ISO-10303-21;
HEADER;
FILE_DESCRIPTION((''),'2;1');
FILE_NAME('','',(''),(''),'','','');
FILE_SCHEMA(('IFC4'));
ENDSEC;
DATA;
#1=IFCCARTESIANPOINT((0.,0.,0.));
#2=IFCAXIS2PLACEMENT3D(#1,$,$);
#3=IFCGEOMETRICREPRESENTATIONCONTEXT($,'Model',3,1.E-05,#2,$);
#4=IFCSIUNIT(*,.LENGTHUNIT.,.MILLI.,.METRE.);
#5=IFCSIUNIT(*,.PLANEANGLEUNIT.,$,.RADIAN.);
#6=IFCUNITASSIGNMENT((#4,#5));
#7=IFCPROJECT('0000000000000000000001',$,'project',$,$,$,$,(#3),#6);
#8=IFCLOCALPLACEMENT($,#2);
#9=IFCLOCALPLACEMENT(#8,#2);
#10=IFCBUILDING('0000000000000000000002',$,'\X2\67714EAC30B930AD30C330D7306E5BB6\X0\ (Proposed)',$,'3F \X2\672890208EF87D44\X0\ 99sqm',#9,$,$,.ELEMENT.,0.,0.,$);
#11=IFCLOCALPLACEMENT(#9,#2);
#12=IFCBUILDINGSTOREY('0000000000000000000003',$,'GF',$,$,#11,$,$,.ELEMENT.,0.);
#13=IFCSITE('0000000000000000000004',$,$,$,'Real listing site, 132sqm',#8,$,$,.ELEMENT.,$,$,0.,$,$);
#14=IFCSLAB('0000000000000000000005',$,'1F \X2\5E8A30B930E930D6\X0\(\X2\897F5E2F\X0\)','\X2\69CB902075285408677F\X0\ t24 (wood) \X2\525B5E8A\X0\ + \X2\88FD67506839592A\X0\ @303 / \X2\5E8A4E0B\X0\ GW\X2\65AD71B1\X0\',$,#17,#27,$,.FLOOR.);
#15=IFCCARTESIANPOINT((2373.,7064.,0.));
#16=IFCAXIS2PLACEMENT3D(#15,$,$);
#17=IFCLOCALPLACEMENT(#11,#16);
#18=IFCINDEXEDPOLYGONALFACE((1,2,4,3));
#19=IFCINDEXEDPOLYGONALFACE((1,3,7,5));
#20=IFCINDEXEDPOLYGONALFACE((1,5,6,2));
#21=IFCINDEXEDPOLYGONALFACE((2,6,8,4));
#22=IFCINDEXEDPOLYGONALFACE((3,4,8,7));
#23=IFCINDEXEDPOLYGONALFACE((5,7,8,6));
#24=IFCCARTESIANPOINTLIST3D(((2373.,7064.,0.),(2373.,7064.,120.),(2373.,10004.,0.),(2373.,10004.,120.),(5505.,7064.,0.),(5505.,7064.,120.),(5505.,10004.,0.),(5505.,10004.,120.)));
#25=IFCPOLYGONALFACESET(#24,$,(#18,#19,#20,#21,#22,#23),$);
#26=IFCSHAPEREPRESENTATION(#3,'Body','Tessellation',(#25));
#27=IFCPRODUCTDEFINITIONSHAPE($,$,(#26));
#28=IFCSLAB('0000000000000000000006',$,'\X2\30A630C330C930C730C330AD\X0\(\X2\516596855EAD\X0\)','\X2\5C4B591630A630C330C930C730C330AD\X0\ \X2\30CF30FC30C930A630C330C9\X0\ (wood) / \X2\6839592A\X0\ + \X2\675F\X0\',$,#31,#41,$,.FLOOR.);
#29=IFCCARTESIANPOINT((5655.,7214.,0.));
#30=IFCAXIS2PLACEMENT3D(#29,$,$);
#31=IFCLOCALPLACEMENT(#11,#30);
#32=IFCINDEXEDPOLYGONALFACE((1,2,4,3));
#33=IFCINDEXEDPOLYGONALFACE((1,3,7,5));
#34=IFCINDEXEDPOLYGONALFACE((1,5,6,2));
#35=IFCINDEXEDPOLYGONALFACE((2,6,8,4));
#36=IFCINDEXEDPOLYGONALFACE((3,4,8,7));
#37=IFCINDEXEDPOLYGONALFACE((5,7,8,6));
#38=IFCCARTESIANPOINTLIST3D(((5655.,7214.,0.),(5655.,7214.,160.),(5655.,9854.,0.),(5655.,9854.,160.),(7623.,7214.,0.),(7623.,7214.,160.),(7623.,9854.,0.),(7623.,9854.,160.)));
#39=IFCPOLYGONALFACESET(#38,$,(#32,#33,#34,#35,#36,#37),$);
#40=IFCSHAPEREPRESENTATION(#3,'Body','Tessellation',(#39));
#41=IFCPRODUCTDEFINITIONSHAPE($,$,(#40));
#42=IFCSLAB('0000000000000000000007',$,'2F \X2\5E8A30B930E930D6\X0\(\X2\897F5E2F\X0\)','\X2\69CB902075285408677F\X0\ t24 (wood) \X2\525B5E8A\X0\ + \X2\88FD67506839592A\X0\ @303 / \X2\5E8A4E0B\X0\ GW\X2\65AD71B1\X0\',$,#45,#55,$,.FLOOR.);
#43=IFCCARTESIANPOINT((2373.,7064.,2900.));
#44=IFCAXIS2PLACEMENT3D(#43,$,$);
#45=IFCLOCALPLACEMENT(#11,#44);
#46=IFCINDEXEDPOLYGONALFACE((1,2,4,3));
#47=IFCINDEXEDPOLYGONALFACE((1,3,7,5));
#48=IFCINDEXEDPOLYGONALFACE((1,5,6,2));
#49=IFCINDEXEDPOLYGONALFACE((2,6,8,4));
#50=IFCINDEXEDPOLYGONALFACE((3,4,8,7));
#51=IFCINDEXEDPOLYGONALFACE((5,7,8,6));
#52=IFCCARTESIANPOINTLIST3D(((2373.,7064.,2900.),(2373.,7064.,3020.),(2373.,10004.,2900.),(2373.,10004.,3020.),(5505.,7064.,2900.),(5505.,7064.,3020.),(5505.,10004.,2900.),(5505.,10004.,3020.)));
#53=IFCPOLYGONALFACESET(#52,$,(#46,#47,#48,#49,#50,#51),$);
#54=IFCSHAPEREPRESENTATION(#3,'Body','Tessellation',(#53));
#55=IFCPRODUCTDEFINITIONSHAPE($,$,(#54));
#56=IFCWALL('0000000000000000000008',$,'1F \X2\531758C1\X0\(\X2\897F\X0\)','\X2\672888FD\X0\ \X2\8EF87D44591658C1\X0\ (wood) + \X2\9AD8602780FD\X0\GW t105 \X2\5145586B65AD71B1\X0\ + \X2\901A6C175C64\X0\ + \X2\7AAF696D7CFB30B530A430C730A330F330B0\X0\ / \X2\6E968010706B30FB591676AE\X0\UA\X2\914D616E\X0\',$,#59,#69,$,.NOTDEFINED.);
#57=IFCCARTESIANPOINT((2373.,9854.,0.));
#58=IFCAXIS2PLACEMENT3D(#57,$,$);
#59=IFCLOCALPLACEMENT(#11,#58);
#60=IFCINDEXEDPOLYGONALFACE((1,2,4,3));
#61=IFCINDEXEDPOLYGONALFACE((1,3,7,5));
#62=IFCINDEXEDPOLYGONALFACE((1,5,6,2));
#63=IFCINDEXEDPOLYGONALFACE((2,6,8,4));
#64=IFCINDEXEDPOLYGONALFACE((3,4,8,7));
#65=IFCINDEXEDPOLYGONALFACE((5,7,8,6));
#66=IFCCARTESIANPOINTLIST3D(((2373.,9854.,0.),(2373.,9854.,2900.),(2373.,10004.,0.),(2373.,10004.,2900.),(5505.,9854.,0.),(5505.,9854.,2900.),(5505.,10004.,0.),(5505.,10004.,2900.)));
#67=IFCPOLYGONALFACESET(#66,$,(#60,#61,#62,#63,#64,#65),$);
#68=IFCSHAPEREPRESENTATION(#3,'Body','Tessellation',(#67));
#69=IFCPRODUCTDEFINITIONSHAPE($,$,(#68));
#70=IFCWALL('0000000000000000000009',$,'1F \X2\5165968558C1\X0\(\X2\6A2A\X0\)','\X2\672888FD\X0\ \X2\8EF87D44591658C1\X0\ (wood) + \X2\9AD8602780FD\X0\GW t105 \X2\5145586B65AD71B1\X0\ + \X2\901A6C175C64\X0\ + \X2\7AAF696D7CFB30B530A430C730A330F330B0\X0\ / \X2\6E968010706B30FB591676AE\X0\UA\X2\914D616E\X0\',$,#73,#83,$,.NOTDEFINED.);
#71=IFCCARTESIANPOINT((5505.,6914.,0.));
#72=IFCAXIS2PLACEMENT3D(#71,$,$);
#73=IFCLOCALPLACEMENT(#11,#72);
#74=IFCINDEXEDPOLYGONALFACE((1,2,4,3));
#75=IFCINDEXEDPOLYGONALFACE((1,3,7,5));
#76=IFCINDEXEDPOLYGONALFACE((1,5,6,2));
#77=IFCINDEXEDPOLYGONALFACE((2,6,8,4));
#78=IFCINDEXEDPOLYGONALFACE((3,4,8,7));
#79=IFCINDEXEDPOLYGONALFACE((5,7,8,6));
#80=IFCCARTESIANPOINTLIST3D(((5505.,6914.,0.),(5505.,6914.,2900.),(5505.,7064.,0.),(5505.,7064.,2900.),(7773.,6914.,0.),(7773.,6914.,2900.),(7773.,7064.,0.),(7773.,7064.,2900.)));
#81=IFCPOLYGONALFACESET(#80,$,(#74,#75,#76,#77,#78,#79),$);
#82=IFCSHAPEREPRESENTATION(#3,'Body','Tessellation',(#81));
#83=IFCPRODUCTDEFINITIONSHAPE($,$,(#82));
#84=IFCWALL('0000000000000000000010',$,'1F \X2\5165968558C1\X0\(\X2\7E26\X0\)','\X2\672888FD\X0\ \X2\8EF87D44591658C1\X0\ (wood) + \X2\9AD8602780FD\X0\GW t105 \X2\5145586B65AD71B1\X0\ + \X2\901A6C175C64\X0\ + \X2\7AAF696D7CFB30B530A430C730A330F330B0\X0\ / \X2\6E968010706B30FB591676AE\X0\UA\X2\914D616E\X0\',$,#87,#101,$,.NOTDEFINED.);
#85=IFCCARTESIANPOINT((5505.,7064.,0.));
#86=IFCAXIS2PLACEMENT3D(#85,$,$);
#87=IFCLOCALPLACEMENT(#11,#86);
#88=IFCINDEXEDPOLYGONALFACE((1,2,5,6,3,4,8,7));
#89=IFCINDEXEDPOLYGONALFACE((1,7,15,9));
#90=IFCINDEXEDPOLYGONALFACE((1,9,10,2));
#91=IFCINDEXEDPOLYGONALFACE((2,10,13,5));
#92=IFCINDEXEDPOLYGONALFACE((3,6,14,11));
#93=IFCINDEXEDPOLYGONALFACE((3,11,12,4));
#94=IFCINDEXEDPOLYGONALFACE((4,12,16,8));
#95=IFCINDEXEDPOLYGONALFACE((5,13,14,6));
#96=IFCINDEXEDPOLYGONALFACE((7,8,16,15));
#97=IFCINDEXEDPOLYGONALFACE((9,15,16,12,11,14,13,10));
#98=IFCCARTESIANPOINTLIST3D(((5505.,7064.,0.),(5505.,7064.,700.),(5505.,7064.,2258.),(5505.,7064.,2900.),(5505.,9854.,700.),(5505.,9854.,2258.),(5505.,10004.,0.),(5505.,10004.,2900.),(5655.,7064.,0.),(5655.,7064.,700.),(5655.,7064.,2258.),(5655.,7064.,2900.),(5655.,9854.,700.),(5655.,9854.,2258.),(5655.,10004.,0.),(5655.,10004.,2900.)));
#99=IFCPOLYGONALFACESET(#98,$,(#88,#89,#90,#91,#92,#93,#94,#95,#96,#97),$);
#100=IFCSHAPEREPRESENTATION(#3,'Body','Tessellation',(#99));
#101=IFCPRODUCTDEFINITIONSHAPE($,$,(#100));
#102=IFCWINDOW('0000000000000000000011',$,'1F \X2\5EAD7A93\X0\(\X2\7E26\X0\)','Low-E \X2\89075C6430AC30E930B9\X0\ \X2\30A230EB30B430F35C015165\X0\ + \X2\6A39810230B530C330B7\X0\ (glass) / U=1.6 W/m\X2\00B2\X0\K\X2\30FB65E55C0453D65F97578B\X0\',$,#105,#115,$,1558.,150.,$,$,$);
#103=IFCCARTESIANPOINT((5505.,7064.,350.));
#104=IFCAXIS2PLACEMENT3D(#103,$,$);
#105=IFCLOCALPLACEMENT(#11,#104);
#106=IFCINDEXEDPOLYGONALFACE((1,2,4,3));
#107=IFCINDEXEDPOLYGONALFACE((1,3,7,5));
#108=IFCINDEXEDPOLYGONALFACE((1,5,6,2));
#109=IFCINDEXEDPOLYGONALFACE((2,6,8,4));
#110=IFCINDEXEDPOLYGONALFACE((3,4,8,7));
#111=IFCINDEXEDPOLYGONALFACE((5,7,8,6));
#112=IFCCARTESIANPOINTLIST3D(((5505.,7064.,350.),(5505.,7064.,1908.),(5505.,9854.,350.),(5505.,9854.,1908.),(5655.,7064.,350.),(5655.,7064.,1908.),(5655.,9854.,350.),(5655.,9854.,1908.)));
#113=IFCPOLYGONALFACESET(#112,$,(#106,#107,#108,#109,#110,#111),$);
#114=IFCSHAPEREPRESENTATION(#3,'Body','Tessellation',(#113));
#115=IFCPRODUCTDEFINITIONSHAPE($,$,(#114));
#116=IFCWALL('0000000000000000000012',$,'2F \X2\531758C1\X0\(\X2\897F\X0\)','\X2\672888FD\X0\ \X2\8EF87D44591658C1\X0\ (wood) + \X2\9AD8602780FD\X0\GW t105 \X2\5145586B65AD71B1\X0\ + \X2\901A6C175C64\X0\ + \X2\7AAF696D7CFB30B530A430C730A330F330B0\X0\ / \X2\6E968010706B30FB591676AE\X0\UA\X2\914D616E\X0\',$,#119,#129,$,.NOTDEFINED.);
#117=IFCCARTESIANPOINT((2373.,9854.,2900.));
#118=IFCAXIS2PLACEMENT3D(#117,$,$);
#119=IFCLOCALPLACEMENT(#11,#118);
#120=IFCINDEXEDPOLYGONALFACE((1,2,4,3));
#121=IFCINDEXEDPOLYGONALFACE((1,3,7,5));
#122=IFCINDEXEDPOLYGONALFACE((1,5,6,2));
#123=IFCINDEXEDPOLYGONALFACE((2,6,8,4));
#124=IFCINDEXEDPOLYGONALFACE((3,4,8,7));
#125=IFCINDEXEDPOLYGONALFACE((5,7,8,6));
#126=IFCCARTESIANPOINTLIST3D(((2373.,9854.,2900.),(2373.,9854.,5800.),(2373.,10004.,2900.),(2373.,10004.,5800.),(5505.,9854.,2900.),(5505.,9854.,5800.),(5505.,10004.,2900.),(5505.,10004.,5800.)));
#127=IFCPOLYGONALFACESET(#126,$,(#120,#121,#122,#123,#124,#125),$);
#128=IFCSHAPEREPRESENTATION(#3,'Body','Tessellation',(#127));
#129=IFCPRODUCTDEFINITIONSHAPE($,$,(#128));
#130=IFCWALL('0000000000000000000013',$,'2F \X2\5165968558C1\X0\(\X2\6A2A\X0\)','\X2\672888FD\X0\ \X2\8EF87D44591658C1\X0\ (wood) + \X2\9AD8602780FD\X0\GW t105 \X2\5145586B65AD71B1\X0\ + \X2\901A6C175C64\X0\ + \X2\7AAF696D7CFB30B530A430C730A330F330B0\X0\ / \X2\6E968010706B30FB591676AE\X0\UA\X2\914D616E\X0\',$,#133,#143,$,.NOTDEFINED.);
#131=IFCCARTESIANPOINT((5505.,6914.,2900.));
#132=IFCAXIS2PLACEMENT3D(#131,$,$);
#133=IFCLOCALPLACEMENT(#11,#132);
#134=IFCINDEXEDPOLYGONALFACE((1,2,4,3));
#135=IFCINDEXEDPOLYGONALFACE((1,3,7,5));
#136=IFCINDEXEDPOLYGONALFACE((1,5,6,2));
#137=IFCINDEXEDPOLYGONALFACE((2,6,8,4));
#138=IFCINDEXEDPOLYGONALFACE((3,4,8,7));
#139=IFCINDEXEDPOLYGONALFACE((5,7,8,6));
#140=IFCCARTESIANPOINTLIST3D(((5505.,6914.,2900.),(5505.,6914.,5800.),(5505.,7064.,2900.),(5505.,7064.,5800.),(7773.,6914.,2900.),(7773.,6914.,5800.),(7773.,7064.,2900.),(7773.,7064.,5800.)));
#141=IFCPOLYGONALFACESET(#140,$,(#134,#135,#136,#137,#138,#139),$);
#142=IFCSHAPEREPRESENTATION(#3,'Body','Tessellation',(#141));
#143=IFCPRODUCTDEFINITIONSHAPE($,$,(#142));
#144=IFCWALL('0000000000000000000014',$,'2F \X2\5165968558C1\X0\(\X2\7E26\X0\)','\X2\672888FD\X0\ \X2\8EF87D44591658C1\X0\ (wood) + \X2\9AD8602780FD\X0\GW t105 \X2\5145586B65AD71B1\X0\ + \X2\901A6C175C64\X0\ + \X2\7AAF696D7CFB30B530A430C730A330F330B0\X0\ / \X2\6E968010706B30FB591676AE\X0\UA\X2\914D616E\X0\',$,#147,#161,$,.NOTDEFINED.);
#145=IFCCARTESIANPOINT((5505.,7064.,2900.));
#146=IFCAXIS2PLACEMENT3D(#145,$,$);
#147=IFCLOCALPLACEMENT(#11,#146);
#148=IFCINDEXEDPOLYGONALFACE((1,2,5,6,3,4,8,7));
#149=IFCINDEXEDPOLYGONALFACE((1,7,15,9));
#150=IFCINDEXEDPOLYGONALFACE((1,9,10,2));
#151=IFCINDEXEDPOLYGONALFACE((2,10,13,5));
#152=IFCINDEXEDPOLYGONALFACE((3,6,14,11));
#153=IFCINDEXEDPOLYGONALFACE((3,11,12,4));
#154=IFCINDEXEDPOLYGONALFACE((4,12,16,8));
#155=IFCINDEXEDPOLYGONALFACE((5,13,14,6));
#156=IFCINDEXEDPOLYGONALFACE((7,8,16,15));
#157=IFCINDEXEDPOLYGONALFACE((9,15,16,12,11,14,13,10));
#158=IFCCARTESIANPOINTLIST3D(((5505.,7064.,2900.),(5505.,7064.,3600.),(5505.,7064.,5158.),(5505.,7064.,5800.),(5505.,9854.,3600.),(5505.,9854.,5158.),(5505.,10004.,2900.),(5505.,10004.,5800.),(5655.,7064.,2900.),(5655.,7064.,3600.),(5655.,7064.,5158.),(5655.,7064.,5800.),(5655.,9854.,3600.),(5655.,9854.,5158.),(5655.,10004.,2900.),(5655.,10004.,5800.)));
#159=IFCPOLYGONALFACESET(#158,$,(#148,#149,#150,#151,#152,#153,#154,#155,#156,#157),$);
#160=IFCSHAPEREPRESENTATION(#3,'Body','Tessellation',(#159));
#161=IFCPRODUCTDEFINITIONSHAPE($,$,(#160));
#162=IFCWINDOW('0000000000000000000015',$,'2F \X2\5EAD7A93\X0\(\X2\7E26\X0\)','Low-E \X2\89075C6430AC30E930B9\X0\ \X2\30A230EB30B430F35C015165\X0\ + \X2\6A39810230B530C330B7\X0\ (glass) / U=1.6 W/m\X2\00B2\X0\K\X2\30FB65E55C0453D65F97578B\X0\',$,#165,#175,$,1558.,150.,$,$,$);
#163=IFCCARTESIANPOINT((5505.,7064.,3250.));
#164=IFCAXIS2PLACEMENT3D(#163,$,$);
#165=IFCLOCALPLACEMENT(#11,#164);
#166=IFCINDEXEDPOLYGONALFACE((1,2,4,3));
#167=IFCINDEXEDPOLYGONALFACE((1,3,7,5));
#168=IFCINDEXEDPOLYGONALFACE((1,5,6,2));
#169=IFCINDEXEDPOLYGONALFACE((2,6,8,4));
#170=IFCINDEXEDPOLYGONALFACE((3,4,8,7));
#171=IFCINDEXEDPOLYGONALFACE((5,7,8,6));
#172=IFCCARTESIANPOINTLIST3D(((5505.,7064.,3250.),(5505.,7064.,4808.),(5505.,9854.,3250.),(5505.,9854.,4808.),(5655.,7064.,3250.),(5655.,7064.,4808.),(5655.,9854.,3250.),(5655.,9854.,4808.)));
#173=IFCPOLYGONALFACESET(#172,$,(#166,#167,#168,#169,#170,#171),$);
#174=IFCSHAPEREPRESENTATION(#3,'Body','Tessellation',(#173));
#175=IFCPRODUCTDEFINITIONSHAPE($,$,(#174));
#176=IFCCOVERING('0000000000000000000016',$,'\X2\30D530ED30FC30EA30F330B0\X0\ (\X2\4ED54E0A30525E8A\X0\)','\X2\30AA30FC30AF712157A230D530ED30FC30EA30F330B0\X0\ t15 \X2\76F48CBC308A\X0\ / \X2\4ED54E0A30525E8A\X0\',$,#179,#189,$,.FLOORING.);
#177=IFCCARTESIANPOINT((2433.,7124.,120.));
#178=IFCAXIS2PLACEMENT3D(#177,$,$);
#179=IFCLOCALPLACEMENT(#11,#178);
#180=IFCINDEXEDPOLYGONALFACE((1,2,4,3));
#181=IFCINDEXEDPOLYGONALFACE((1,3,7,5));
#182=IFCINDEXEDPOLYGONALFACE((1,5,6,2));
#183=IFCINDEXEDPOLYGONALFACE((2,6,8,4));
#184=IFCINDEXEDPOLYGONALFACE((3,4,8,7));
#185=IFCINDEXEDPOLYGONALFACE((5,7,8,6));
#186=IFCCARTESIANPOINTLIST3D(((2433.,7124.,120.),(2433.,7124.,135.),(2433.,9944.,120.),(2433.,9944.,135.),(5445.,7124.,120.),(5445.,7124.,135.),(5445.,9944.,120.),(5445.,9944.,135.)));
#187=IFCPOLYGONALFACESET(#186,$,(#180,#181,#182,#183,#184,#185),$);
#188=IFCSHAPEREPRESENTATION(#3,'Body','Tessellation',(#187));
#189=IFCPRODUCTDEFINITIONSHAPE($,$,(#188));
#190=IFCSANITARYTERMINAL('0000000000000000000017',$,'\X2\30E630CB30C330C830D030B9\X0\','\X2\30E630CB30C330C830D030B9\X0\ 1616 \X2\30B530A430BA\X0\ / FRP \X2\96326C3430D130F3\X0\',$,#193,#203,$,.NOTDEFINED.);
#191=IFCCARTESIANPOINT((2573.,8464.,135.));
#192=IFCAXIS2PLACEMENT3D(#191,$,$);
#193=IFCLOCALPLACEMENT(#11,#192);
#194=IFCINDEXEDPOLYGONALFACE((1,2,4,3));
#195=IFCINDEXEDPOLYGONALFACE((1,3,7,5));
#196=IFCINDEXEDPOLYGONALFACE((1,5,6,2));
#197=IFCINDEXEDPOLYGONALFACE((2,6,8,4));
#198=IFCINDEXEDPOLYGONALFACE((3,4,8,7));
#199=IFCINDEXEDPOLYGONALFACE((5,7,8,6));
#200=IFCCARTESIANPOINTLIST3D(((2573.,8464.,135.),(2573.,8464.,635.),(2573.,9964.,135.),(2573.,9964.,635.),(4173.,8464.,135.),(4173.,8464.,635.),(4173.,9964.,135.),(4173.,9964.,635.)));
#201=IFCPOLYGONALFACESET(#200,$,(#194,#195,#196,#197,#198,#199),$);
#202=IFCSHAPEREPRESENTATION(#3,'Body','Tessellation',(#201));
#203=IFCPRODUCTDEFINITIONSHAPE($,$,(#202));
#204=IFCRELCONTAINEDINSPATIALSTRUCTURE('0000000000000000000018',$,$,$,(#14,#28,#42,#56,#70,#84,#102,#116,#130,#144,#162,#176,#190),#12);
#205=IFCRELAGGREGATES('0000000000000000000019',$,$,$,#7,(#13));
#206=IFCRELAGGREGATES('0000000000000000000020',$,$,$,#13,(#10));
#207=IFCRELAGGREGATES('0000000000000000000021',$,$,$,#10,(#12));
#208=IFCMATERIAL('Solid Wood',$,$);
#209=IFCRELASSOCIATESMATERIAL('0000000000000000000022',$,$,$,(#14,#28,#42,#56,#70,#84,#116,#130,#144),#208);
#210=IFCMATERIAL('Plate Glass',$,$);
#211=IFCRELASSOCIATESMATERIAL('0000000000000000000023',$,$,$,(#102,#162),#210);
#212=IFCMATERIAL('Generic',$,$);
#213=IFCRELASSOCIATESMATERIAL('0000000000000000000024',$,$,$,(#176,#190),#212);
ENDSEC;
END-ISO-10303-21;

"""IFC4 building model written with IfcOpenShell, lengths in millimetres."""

from ifc_helpers import new_model, si_unit, frame, frame_2d, origin, place, context, project, spatial, rectangle, extrude, material, element, fill, save


model = new_model("IFC4")

# Units and contexts
model_context = context("Model", 3, precision=1e-05, world=origin())
ifc_project = project(units=[si_unit("LENGTHUNIT", "METRE", prefix="MILLI"), si_unit("PLANEANGLEUNIT", "RADIAN")], contexts=[model_context])

# Site, building, storey
site_placement = place(None, origin())
site = spatial("IfcSite", under=ifc_project, at=site_placement, ObjectType="Real listing site, 132sqm", CompositionType="ELEMENT", RefElevation=0.0)
building_placement = place(site_placement, origin())
building = spatial("IfcBuilding", under=site, at=building_placement, Name="東京スキップの家 (Proposed)", ObjectType="3F 木造軸組 99sqm", CompositionType="ELEMENT", ElevationOfRefHeight=0.0, ElevationOfTerrain=0.0)
storey_placement = place(building_placement, origin())
storey = spatial("IfcBuildingStorey", under=building, at=storey_placement, Name="GF", CompositionType="ELEMENT", Elevation=0.0)

# Slabs
ifc_material_1 = material(Name="Solid Wood")
slab_1_placement = place(storey_placement, frame((2373.0, 7064.0, 0.0)))
element("IfcSlab", 1, at=slab_1_placement, inside=storey, material=ifc_material_1, Name="1F 床スラブ(西帯)", Description="構造用合板 t24 (wood) 剛床 + 製材根太 @303 / 床下 GW断熱", PredefinedType="FLOOR", context=model_context, shape_type="SweptSolid", body=[
    extrude(rectangle(XDim=3132.0, YDim=2940.0, at=frame_2d((1566.0, 1470.0))), frame((2373.0, 7064.0, 0.0)), (0.0, 0.0, 1.0), 120.0),
])
slab_2_placement = place(storey_placement, frame((5655.0, 7214.0, 0.0)))
element("IfcSlab", 2, at=slab_2_placement, inside=storey, material=ifc_material_1, Name="ウッドデッキ(入隅庭)", Description="屋外ウッドデッキ ハードウッド (wood) / 根太 + 束", PredefinedType="FLOOR", context=model_context, shape_type="SweptSolid", body=[
    extrude(rectangle(XDim=1968.0, YDim=2640.0, at=frame_2d((984.0, 1320.0))), frame((5655.0, 7214.0, 0.0)), (0.0, 0.0, 1.0), 160.0),
])
slab_3_placement = place(storey_placement, frame((2373.0, 7064.0, 2900.0)))
element("IfcSlab", 3, at=slab_3_placement, inside=storey, material=ifc_material_1, Name="2F 床スラブ(西帯)", Description="構造用合板 t24 (wood) 剛床 + 製材根太 @303 / 床下 GW断熱", PredefinedType="FLOOR", context=model_context, shape_type="SweptSolid", body=[
    extrude(rectangle(XDim=3132.0, YDim=2940.0, at=frame_2d((1566.0, 1470.0))), frame((2373.0, 7064.0, 2900.0)), (0.0, 0.0, 1.0), 120.0),
])

# Walls
wall_1_placement = place(storey_placement, frame((2373.0, 9854.0, 0.0)))
element("IfcWall", 4, at=wall_1_placement, inside=storey, material=ifc_material_1, Name="1F 北壁(西)", Description="木製 軸組外壁 (wood) + 高性能GW t105 充填断熱 + 通気層 + 窯業系サイディング / 準耐火・外皮UA配慮", PredefinedType="NOTDEFINED", context=model_context, shape_type="SweptSolid", body=[
    extrude(rectangle(XDim=3132.0, YDim=150.0, at=frame_2d((1566.0, 75.0))), frame((2373.0, 9854.0, 0.0)), (0.0, 0.0, 1.0), 2900.0),
])
wall_2_placement = place(storey_placement, frame((5505.0, 6914.0, 0.0)))
element("IfcWall", 5, at=wall_2_placement, inside=storey, material=ifc_material_1, Name="1F 入隅壁(横)", Description="木製 軸組外壁 (wood) + 高性能GW t105 充填断熱 + 通気層 + 窯業系サイディング / 準耐火・外皮UA配慮", PredefinedType="NOTDEFINED", context=model_context, shape_type="SweptSolid", body=[
    extrude(rectangle(XDim=2268.0, YDim=150.0, at=frame_2d((1134.0, 75.0))), frame((5505.0, 6914.0, 0.0)), (0.0, 0.0, 1.0), 2900.0),
])

# Wall, opening, window
wall_3_placement = place(storey_placement, frame((5505.0, 7064.0, 0.0)))
wall_3 = element("IfcWall", 6, at=wall_3_placement, inside=storey, material=ifc_material_1, Name="1F 入隅壁(縦)", Description="木製 軸組外壁 (wood) + 高性能GW t105 充填断熱 + 通気層 + 窯業系サイディング / 準耐火・外皮UA配慮", PredefinedType="NOTDEFINED", context=model_context, shape_type="SweptSolid", body=[
    extrude(rectangle(XDim=150.0, YDim=2940.0, at=frame_2d((75.0, 1470.0))), frame((5505.0, 7064.0, 0.0)), (0.0, 0.0, 1.0), 2900.0),
])
opening_1_placement = place(storey_placement, frame((5505.0, 7064.0, 350.0)))
opening_1 = element("IfcOpeningElement", 7, at=opening_1_placement, cuts=wall_3, PredefinedType="NOTDEFINED", context=model_context, shape_type="SweptSolid", body=[
    extrude(rectangle(XDim=150.0, YDim=2790.0, at=frame_2d((75.0, 1395.0))), frame((5505.0, 7064.0, 350.0)), (0.0, 0.0, 1.0), 1558.0),
])
ifc_material_2 = material(Name="Plate Glass")
window_1_placement = place(storey_placement, frame((5505.0, 7064.0, 350.0)))
window_1 = element("IfcWindow", 8, at=window_1_placement, inside=storey, material=ifc_material_2, Name="1F 庭窓(縦)", Description="Low-E 複層ガラス アルゴン封入 + 樹脂サッシ (glass) / U=1.6 W/m²K・日射取得型", OverallHeight=1558.0, OverallWidth=150.0, context=model_context, shape_type="SweptSolid", body=[
    extrude(rectangle(XDim=150.0, YDim=2790.0, at=frame_2d((75.0, 1395.0))), frame((5505.0, 7064.0, 350.0)), (0.0, 0.0, 1.0), 1558.0),
])
fill(opening_1, window_1)

# Walls
wall_4_placement = place(storey_placement, frame((2373.0, 9854.0, 2900.0)))
element("IfcWall", 9, at=wall_4_placement, inside=storey, material=ifc_material_1, Name="2F 北壁(西)", Description="木製 軸組外壁 (wood) + 高性能GW t105 充填断熱 + 通気層 + 窯業系サイディング / 準耐火・外皮UA配慮", PredefinedType="NOTDEFINED", context=model_context, shape_type="SweptSolid", body=[
    extrude(rectangle(XDim=3132.0, YDim=150.0, at=frame_2d((1566.0, 75.0))), frame((2373.0, 9854.0, 2900.0)), (0.0, 0.0, 1.0), 2900.0),
])
wall_5_placement = place(storey_placement, frame((5505.0, 6914.0, 2900.0)))
element("IfcWall", 10, at=wall_5_placement, inside=storey, material=ifc_material_1, Name="2F 入隅壁(横)", Description="木製 軸組外壁 (wood) + 高性能GW t105 充填断熱 + 通気層 + 窯業系サイディング / 準耐火・外皮UA配慮", PredefinedType="NOTDEFINED", context=model_context, shape_type="SweptSolid", body=[
    extrude(rectangle(XDim=2268.0, YDim=150.0, at=frame_2d((1134.0, 75.0))), frame((5505.0, 6914.0, 2900.0)), (0.0, 0.0, 1.0), 2900.0),
])

# Wall, opening, window
wall_6_placement = place(storey_placement, frame((5505.0, 7064.0, 2900.0)))
wall_6 = element("IfcWall", 11, at=wall_6_placement, inside=storey, material=ifc_material_1, Name="2F 入隅壁(縦)", Description="木製 軸組外壁 (wood) + 高性能GW t105 充填断熱 + 通気層 + 窯業系サイディング / 準耐火・外皮UA配慮", PredefinedType="NOTDEFINED", context=model_context, shape_type="SweptSolid", body=[
    extrude(rectangle(XDim=150.0, YDim=2940.0, at=frame_2d((75.0, 1470.0))), frame((5505.0, 7064.0, 2900.0)), (0.0, 0.0, 1.0), 2900.0),
])
opening_2_placement = place(storey_placement, frame((5505.0, 7064.0, 3250.0)))
opening_2 = element("IfcOpeningElement", 12, at=opening_2_placement, cuts=wall_6, PredefinedType="NOTDEFINED", context=model_context, shape_type="SweptSolid", body=[
    extrude(rectangle(XDim=150.0, YDim=2790.0, at=frame_2d((75.0, 1395.0))), frame((5505.0, 7064.0, 3250.0)), (0.0, 0.0, 1.0), 1558.0),
])
window_2_placement = place(storey_placement, frame((5505.0, 7064.0, 3250.0)))
window_2 = element("IfcWindow", 13, at=window_2_placement, inside=storey, material=ifc_material_2, Name="2F 庭窓(縦)", Description="Low-E 複層ガラス アルゴン封入 + 樹脂サッシ (glass) / U=1.6 W/m²K・日射取得型", OverallHeight=1558.0, OverallWidth=150.0, context=model_context, shape_type="SweptSolid", body=[
    extrude(rectangle(XDim=150.0, YDim=2790.0, at=frame_2d((75.0, 1395.0))), frame((5505.0, 7064.0, 3250.0)), (0.0, 0.0, 1.0), 1558.0),
])
fill(opening_2, window_2)

# Covering
ifc_material_3 = material(Name="Generic")
covering_placement = place(storey_placement, frame((2433.0, 7124.0, 120.0)))
element("IfcCovering", 14, at=covering_placement, inside=storey, material=ifc_material_3, Name="フローリング (仕上げ床)", Description="オーク無垢フローリング t15 直貼り / 仕上げ床", PredefinedType="FLOORING", context=model_context, shape_type="SweptSolid", body=[
    extrude(rectangle(XDim=3012.0, YDim=2820.0, at=frame_2d((1506.0, 1410.0))), frame((2433.0, 7124.0, 120.0)), (0.0, 0.0, 1.0), 15.0),
])

# Sanitary terminal
sanitary_terminal_1_placement = place(storey_placement, frame((2573.0, 8464.0, 135.0)))
element("IfcSanitaryTerminal", 15, at=sanitary_terminal_1_placement, inside=storey, material=ifc_material_3, Name="ユニットバス", Description="ユニットバス 1616 サイズ / FRP 防水パン", PredefinedType="NOTDEFINED", context=model_context, shape_type="SweptSolid", body=[
    extrude(rectangle(XDim=1600.0, YDim=1500.0, at=frame_2d((800.0, 750.0))), frame((2573.0, 8464.0, 135.0)), (0.0, 0.0, 1.0), 500.0),
])

save(model, "model.ifc")
